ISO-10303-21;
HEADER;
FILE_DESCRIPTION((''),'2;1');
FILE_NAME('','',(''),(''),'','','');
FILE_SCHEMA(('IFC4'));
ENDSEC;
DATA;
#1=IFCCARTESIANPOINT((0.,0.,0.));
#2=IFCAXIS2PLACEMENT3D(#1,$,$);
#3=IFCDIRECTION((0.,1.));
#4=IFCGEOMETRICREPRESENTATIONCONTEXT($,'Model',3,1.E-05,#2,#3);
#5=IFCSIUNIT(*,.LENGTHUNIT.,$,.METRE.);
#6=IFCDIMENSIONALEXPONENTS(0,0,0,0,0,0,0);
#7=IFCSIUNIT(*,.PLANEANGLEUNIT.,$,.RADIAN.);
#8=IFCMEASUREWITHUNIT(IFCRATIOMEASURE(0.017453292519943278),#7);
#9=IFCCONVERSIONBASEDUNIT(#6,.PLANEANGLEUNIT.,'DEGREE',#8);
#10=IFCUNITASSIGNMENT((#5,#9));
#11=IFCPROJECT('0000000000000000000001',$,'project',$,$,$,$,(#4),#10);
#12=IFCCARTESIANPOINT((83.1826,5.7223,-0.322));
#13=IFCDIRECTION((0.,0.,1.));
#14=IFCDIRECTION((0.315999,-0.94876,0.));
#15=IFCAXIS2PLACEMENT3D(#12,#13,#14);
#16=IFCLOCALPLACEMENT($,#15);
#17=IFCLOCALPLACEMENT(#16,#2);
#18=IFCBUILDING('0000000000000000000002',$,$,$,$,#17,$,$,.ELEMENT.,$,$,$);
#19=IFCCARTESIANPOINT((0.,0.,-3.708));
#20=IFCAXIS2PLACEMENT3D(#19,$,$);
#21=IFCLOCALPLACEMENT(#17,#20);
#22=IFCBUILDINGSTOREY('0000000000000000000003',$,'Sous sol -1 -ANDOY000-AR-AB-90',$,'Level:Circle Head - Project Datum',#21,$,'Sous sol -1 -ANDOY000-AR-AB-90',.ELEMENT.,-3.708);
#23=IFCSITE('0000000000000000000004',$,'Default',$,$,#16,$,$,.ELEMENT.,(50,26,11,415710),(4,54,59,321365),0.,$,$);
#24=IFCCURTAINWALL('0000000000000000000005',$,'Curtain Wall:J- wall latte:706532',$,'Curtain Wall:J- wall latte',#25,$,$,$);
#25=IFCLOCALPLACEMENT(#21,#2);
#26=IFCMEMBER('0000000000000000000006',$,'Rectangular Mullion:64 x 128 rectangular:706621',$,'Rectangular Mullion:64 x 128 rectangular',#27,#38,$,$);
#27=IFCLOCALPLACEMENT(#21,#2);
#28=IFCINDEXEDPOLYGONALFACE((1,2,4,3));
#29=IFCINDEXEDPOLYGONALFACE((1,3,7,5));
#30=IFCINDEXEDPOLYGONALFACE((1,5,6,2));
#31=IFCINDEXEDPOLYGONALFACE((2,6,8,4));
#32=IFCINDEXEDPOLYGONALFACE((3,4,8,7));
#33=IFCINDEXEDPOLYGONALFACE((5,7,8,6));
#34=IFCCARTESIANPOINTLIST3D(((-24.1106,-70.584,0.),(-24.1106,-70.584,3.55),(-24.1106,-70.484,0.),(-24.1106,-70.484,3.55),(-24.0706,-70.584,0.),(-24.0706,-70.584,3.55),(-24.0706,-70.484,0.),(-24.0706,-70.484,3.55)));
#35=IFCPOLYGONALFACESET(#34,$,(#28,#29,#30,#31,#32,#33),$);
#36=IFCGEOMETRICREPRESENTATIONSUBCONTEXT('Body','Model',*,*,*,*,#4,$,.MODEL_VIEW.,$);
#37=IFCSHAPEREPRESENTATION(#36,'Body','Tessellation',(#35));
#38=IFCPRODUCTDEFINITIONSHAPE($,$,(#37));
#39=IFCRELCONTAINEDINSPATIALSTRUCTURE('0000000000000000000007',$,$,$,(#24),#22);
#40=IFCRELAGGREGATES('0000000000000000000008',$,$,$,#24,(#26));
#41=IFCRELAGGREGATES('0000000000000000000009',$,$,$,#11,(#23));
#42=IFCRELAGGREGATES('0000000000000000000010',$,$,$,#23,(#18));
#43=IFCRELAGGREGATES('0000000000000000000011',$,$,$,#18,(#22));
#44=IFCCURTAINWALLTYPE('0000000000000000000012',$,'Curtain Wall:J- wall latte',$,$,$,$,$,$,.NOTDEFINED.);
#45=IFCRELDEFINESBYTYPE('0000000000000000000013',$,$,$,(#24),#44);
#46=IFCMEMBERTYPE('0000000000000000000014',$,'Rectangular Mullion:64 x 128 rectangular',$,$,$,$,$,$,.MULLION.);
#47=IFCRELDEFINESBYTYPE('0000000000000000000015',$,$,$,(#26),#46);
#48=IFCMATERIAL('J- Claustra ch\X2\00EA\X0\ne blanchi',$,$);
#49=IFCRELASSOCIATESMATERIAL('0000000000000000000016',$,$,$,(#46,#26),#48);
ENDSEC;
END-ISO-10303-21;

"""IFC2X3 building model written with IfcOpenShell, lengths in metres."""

from ifc_helpers import new_model, entity, si_unit, converted_unit, direction, frame, origin, origin_2d_with_axis, place, context, subcontext, project, spatial, rectangle, extrude, source, transform, mapped, material, type_object, type_shapes, element, aggregate, save


model = new_model("IFC2X3")

# Units and contexts
model_context = context("Model", 3, precision=1e-05, world=origin(), true_north=direction((0.0, 1.0)))
body_context = subcontext(model_context, "Body", "Model", "MODEL_VIEW")
ifc_project = project(units=[si_unit("LENGTHUNIT", "METRE"), converted_unit("PLANEANGLEUNIT", "DEGREE", entity("IfcRatioMeasure", 0.017453292519943278), si_unit("PLANEANGLEUNIT", "RADIAN"), dimensions=[0, 0, 0, 0, 0, 0, 0])], contexts=[model_context])

# Site, building, storey
site_placement = place(None, frame((83.1826, 5.7223, -0.322), z_axis=(0.0, 0.0, 1.0), x_axis=(0.315999, -0.94876, 0.0)))
site = spatial("IfcSite", under=ifc_project, at=site_placement, Name="Default", CompositionType="ELEMENT", RefLatitude=(50, 26, 11, 415710), RefLongitude=(4, 54, 59, 321365), RefElevation=0.0)
building_placement = place(site_placement, origin())
building = spatial("IfcBuilding", under=site, at=building_placement, CompositionType="ELEMENT")
storey_placement = place(building_placement, frame((0.0, 0.0, -3.708)))
storey = spatial("IfcBuildingStorey", under=building, at=storey_placement, Name="Sous sol -1 -ANDOY000-AR-AB-90", ObjectType="Level:Circle Head - Project Datum", LongName="Sous sol -1 -ANDOY000-AR-AB-90", CompositionType="ELEMENT", Elevation=-3.708)

# Curtain wall, member
curtain_wall_type_1 = type_object("IfcCurtainWallType", Name="Curtain Wall:J- wall latte", PredefinedType="NOTDEFINED")
curtain_wall_1_placement = place(storey_placement, frame((0.0, 0.0, 3.708)))
curtain_wall_1 = element("IfcCurtainWall", 1, at=curtain_wall_1_placement, inside=storey, type_object=curtain_wall_type_1, Name="Curtain Wall:J- wall latte:706532", ObjectType="Curtain Wall:J- wall latte")
ifc_material_1 = material(Name="J- Claustra chêne blanchi")
member_type_1 = type_object("IfcMemberType", Name="Rectangular Mullion:64 x 128 rectangular", PredefinedType="MULLION", material=ifc_material_1)
shared_shape_1 = source(origin(), body_context, "Body", "SweptSolid", [
    extrude(rectangle(XDim=0.1, YDim=0.04, at=origin_2d_with_axis()), frame((0.0, 0.0, -3.55), z_axis=(0.0, 0.0, 1.0), x_axis=(0.0, -1.0, 0.0)), (0.0, 0.0, 1.0), 3.55),
])
type_shapes(member_type_1, [shared_shape_1])
member_1_placement = place(curtain_wall_1_placement, frame((-24.0906, -70.534, -3.708), z_axis=(0.0, 0.0, -1.0), x_axis=(1.0, 0.0, 0.0)))
member_1 = element("IfcMember", 2, at=member_1_placement, type_object=member_type_1, material=ifc_material_1, Name="Rectangular Mullion:64 x 128 rectangular:706621", ObjectType="Rectangular Mullion:64 x 128 rectangular", context=body_context, shape_type="MappedRepresentation", body=[
    mapped(shared_shape_1, transform((0.0, 0.0, 0.0), scale=1.0)),
])

aggregate(curtain_wall_1, [member_1])

save(model, "model.ifc")
